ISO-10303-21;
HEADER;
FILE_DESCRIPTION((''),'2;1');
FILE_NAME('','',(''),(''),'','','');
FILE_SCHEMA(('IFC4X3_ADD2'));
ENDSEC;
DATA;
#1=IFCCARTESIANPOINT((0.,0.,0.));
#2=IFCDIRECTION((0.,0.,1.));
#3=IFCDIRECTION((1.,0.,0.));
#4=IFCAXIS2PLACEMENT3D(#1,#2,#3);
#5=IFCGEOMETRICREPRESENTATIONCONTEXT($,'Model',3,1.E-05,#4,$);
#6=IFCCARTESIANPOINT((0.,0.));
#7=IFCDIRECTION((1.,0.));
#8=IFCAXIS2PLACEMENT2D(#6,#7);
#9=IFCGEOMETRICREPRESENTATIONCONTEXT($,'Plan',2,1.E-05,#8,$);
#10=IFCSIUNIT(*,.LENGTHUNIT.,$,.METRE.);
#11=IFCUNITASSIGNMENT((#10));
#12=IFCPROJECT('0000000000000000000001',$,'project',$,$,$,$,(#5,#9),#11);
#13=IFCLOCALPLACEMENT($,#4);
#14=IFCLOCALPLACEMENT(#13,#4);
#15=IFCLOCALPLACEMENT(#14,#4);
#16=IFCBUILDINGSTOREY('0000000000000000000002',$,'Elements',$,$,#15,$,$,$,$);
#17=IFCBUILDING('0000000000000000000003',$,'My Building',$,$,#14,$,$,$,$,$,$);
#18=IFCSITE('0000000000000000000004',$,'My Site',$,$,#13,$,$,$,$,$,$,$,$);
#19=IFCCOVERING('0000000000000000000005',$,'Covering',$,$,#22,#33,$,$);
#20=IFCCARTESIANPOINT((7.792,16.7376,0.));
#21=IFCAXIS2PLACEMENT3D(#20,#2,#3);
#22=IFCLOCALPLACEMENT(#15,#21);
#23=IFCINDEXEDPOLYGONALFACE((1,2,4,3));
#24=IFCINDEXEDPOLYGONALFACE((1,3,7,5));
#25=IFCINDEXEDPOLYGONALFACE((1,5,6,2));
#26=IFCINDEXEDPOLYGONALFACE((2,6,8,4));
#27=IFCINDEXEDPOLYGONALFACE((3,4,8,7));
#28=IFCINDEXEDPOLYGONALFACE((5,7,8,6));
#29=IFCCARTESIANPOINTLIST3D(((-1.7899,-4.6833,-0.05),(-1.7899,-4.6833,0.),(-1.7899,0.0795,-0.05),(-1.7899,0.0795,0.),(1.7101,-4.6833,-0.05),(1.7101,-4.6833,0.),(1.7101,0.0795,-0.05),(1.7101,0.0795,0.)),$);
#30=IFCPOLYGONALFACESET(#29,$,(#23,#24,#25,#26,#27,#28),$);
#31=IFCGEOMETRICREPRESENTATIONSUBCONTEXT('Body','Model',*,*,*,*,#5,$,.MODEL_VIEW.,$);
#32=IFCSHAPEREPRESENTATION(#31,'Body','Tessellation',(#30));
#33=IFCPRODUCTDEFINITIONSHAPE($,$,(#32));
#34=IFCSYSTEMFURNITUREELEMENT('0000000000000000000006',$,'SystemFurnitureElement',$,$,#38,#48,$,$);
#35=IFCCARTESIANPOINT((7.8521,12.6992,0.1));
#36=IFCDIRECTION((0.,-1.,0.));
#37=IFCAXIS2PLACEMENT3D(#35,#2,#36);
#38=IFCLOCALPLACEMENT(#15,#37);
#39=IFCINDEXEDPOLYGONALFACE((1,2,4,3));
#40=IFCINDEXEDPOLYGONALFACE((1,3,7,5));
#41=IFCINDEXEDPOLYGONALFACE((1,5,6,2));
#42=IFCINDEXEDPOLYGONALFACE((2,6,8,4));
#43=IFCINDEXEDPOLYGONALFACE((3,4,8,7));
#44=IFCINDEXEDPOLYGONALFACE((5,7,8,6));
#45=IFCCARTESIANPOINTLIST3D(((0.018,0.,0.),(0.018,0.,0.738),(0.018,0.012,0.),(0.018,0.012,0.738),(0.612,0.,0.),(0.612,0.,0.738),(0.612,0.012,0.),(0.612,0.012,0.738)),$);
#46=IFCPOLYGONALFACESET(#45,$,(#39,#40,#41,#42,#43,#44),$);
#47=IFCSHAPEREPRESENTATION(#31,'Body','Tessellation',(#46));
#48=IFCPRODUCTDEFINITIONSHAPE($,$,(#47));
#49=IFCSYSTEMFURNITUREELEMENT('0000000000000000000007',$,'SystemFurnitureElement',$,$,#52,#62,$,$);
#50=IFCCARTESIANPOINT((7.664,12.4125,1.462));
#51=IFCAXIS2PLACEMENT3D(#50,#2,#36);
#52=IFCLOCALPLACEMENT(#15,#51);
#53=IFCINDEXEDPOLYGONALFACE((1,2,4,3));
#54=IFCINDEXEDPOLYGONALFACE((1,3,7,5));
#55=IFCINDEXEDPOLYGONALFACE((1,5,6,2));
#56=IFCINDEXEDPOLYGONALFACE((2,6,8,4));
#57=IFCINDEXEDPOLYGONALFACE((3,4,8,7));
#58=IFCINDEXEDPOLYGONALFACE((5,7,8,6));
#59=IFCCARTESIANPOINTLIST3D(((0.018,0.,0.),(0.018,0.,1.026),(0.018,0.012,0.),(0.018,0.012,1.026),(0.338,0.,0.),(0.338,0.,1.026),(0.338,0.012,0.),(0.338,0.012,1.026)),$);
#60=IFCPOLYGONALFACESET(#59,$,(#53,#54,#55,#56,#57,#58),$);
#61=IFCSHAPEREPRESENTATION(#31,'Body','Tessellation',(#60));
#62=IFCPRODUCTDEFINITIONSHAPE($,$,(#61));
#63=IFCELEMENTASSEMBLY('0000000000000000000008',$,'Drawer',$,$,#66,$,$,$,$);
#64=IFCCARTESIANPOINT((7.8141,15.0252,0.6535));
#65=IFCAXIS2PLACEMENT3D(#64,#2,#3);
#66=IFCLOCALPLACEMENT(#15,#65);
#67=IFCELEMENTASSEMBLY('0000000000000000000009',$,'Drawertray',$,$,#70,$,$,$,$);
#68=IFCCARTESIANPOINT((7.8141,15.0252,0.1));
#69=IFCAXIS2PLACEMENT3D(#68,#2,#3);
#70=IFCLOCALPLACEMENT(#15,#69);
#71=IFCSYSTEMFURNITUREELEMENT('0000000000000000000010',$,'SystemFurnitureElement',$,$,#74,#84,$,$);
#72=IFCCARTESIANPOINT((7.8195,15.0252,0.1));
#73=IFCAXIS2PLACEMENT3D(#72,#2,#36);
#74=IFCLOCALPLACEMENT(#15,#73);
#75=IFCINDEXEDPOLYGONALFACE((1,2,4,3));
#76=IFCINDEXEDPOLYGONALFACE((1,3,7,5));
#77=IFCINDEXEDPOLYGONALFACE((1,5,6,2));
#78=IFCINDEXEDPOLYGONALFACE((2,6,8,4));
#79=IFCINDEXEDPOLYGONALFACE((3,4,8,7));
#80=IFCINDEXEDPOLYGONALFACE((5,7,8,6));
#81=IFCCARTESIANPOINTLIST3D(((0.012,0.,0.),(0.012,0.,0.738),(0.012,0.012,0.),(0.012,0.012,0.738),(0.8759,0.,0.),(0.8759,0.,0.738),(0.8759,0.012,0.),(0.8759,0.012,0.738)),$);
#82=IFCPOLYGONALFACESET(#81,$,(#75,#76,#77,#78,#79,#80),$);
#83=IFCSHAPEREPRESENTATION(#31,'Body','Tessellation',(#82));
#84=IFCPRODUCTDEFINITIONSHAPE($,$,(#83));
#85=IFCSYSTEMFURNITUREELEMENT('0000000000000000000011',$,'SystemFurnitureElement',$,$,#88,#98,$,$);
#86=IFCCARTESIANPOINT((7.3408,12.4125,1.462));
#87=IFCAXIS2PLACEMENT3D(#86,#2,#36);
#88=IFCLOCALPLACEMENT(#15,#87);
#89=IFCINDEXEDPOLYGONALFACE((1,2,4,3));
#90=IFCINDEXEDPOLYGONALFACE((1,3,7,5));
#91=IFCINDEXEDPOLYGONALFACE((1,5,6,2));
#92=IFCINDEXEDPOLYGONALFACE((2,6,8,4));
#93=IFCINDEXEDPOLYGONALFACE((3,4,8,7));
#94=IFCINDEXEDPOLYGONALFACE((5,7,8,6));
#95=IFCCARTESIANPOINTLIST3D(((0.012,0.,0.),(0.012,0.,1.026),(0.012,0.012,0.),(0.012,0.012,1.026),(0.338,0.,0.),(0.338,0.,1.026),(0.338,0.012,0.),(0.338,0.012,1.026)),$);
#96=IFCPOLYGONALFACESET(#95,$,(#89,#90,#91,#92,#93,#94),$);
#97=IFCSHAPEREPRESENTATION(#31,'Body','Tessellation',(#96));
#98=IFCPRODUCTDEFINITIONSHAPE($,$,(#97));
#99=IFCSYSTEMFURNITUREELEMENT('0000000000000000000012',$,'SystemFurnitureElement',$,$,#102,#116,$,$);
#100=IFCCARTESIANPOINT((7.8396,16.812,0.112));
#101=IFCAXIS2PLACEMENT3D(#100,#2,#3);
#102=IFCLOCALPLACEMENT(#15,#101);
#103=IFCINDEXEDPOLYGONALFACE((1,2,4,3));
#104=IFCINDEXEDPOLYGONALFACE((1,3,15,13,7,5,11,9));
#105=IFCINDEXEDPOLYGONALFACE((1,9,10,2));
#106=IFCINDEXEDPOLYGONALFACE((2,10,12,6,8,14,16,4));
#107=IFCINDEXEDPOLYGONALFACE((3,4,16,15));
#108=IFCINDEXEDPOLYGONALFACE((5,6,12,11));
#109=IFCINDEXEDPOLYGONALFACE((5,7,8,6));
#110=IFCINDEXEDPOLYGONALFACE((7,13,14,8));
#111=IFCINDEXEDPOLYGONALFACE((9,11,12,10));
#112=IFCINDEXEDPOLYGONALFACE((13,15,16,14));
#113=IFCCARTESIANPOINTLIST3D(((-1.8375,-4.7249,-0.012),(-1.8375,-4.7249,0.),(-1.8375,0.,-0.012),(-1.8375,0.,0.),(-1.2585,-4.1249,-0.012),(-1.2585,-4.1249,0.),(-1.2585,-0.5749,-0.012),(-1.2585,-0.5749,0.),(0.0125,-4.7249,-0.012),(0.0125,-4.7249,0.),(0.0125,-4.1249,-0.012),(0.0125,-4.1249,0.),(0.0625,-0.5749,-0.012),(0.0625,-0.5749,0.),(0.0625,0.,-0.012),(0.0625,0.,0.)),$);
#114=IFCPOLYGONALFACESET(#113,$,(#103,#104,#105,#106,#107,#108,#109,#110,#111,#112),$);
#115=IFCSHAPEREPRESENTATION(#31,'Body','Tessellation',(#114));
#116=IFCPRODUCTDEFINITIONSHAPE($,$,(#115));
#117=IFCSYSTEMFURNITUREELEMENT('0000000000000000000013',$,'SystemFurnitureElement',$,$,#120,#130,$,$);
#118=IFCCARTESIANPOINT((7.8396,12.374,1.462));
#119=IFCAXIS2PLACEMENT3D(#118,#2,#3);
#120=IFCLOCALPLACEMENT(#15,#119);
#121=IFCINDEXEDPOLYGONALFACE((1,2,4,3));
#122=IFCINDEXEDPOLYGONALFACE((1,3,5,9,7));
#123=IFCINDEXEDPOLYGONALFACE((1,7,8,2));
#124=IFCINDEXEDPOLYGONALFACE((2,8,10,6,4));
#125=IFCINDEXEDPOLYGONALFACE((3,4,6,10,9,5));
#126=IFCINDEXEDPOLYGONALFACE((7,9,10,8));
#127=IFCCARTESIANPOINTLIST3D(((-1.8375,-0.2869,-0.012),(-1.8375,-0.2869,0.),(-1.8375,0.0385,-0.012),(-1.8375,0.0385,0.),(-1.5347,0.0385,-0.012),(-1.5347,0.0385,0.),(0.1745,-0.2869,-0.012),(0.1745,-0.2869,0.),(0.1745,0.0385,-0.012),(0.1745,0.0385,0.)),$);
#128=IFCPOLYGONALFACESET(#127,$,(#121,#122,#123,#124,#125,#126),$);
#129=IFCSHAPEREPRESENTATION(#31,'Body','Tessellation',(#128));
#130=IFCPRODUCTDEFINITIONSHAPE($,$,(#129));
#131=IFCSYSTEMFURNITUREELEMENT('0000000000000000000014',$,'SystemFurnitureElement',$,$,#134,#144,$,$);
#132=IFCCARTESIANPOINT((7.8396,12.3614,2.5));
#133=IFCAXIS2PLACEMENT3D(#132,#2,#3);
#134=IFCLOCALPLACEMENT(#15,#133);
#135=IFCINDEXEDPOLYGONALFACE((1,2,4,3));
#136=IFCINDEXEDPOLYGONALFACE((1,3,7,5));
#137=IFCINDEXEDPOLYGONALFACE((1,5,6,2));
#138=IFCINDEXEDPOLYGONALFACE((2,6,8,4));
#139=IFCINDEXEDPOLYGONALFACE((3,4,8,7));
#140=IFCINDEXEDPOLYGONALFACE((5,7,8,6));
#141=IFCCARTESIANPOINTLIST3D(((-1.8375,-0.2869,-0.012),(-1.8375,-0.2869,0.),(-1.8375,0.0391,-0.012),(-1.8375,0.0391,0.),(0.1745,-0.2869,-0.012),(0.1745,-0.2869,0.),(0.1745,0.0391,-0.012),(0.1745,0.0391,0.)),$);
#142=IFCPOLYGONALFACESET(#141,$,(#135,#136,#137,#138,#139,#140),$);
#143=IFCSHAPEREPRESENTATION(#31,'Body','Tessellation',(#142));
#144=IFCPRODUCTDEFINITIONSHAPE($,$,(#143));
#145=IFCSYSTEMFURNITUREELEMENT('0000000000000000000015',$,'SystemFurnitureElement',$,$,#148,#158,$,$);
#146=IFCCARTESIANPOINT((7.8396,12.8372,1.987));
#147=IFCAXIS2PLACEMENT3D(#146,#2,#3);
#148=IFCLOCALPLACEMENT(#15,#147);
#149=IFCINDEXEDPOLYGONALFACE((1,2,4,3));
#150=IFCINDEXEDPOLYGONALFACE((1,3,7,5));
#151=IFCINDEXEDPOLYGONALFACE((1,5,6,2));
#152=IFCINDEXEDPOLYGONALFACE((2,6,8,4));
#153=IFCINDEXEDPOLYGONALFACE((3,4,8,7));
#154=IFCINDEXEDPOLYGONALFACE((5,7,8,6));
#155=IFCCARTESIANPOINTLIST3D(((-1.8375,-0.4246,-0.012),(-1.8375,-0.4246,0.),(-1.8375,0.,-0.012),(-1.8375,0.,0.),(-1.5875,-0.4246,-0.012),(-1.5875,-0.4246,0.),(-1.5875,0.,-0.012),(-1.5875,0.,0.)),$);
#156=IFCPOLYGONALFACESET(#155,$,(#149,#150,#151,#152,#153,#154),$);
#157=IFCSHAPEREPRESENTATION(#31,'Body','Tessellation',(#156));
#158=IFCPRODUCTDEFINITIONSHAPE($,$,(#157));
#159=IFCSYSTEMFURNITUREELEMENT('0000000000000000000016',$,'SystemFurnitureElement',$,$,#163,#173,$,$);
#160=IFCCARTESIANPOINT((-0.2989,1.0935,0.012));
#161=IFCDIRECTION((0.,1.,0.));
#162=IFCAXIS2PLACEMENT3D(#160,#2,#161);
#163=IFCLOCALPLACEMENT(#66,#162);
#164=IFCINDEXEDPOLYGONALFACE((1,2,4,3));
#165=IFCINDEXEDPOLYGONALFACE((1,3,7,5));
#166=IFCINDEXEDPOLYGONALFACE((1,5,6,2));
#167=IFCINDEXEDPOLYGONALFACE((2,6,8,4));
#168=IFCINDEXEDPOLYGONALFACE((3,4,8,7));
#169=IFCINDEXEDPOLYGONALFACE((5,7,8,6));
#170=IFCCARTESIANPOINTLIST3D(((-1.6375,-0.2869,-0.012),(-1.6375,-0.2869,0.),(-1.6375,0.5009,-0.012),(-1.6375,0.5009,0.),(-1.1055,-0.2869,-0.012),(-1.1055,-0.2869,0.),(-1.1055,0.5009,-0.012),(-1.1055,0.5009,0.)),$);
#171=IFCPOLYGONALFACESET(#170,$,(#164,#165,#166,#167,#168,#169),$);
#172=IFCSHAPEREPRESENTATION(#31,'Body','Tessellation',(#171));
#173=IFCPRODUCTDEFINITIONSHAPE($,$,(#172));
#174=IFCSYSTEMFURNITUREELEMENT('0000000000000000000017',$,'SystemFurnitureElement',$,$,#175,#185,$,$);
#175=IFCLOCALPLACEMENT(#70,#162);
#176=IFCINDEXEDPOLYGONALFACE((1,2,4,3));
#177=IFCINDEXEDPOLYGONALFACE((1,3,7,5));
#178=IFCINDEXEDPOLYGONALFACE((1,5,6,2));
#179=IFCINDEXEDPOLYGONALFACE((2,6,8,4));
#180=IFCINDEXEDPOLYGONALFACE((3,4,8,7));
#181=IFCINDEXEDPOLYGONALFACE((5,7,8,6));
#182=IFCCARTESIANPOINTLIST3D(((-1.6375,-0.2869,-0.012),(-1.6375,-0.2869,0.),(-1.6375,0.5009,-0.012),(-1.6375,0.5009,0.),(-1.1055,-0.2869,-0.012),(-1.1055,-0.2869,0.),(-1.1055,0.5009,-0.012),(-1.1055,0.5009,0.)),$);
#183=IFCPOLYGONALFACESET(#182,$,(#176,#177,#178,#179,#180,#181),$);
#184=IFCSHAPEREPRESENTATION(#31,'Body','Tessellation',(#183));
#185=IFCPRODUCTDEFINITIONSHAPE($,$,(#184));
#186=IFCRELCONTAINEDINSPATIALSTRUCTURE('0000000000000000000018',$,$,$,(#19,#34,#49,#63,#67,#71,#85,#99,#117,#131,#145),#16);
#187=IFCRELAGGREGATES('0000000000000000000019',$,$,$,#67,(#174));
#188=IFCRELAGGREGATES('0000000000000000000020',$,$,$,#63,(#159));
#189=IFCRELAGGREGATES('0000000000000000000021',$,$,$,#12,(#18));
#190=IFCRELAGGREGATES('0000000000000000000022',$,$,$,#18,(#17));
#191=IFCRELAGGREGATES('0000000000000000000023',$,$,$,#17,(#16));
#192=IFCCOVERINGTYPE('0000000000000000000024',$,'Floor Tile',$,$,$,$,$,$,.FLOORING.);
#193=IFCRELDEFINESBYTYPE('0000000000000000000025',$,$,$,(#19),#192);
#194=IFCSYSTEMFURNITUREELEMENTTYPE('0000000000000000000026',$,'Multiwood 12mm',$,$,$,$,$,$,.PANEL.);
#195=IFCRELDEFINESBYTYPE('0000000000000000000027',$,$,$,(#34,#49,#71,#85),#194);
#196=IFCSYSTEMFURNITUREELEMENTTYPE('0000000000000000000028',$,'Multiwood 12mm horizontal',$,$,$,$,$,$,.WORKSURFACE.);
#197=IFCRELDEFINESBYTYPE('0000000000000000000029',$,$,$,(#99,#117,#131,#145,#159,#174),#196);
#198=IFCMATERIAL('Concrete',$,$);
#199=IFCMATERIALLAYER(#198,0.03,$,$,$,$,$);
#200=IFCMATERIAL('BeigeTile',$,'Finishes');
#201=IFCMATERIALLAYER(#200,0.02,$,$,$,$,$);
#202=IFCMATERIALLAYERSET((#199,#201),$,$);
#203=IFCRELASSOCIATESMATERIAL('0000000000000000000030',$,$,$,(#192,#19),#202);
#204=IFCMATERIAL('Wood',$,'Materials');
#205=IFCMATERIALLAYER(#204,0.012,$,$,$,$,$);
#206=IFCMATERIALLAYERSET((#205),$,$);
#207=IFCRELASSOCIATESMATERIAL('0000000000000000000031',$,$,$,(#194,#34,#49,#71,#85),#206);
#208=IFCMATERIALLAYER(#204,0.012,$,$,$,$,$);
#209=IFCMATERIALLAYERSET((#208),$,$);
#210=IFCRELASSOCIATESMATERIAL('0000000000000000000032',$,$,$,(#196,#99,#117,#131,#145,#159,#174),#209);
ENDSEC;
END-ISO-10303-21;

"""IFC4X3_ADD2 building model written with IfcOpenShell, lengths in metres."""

from ifc_helpers import new_model, si_unit, frame, origin_with_axes, origin_2d_with_axis, place, context, subcontext, project, spatial, line, indexed_curve, outline, extrude, material, layer, layer_set, layer_usage, type_object, element, aggregate, save


model = new_model("IFC4X3_ADD2")

# Units and contexts
model_context = context("Model", 3, precision=1e-05, world=origin_with_axes())
plan_context = context("Plan", 2, precision=1e-05, world=origin_2d_with_axis())
body_context = subcontext(model_context, "Body", "Model", "MODEL_VIEW")
ifc_project = project(units=[si_unit("LENGTHUNIT", "METRE")], contexts=[model_context, plan_context])

# Site, building, storey
site_placement = place(None, origin_with_axes())
site = spatial("IfcSite", under=ifc_project, at=site_placement, Name="My Site")
building_placement = place(site_placement, origin_with_axes())
building = spatial("IfcBuilding", under=site, at=building_placement, Name="My Building")
storey_placement = place(building_placement, origin_with_axes())
storey = spatial("IfcBuildingStorey", under=building, at=storey_placement, Name="Elements")

# Covering
ifc_material_1 = material(Name="Concrete")
ifc_layer_1 = layer(ifc_material_1, 0.03)
ifc_material_2 = material(Name="BeigeTile", Category="Finishes")
ifc_layer_2 = layer(ifc_material_2, 0.02)
ifc_layer_set_1 = layer_set([ifc_layer_1, ifc_layer_2])
ifc_layer_usage_1 = layer_usage(ifc_layer_set_1, "AXIS3", "POSITIVE", -0.05)
covering_type = type_object("IfcCoveringType", Name="Floor Tile", PredefinedType="FLOORING", material=ifc_layer_set_1)
covering_placement = place(storey_placement, frame((7.792, 16.7376, 0.0), z_axis=(0.0, 0.0, 1.0), x_axis=(1.0, 0.0, 0.0)))
element("IfcCovering", 1, at=covering_placement, inside=storey, type_object=covering_type, material=ifc_layer_usage_1, Name="Covering", context=body_context, shape_type="SweptSolid", body=[
    extrude(outline(indexed_curve([(-1.7899, -4.6833), (1.7101, -4.6833), (1.7101, 0.0795), (-1.7899, 0.0795), (-1.7899, -4.6833)])), frame((0.0, 0.0, -0.05), z_axis=(0.0, 0.0, 1.0), x_axis=(1.0, 0.0, 0.0)), (0.0, 0.0, 1.0), 0.05),
])

# System furniture elements
ifc_material_3 = material(Name="Wood", Category="Materials")
ifc_layer_3 = layer(ifc_material_3, 0.012)
ifc_layer_set_2 = layer_set([ifc_layer_3])
ifc_layer_usage_2 = layer_usage(ifc_layer_set_2, "AXIS2", "POSITIVE", 0.0)
system_furniture_element_type_1 = type_object("IfcSystemFurnitureElementType", Name="Multiwood 12mm", PredefinedType="PANEL", material=ifc_layer_set_2)
system_furniture_element_1_placement = place(storey_placement, frame((7.8521, 12.6992, 0.1), z_axis=(0.0, 0.0, 1.0), x_axis=(0.0, -1.0, 0.0)))
element("IfcSystemFurnitureElement", 2, at=system_furniture_element_1_placement, inside=storey, type_object=system_furniture_element_type_1, material=ifc_layer_usage_2, Name="SystemFurnitureElement", context=body_context, shape_type="SweptSolid", body=[
    extrude(outline(indexed_curve([(0.018, 0.0), (0.018, 0.012), (0.612, 0.012), (0.612, 0.0)], segments=[line(1, 2, 3, 4, 1)])), origin_with_axes(), (0.0, 0.0, 1.0), 0.738),
])
ifc_layer_usage_3 = layer_usage(ifc_layer_set_2, "AXIS2", "POSITIVE", 0.0)
system_furniture_element_2_placement = place(storey_placement, frame((7.664, 12.4125, 1.462), z_axis=(0.0, 0.0, 1.0), x_axis=(0.0, -1.0, 0.0)))
element("IfcSystemFurnitureElement", 3, at=system_furniture_element_2_placement, inside=storey, type_object=system_furniture_element_type_1, material=ifc_layer_usage_3, Name="SystemFurnitureElement", context=body_context, shape_type="SweptSolid", body=[
    extrude(outline(indexed_curve([(0.018, 0.0), (0.018, 0.012), (0.338, 0.012), (0.338, 0.0)], segments=[line(1, 2, 3, 4, 1)])), origin_with_axes(), (0.0, 0.0, 1.0), 1.026),
])

# Element assemblies
assembly_1_placement = place(storey_placement, frame((7.8141, 15.0252, 0.6535), z_axis=(0.0, 0.0, 1.0), x_axis=(1.0, 0.0, 0.0)))
assembly_1 = element("IfcElementAssembly", 4, at=assembly_1_placement, inside=storey, Name="Drawer")
assembly_2_placement = place(storey_placement, frame((7.8141, 15.0252, 0.1), z_axis=(0.0, 0.0, 1.0), x_axis=(1.0, 0.0, 0.0)))
assembly_2 = element("IfcElementAssembly", 5, at=assembly_2_placement, inside=storey, Name="Drawertray")

# System furniture elements
ifc_layer_usage_4 = layer_usage(ifc_layer_set_2, "AXIS2", "POSITIVE", 0.0)
system_furniture_element_3_placement = place(storey_placement, frame((7.8195, 15.0252, 0.1), z_axis=(0.0, 0.0, 1.0), x_axis=(0.0, -1.0, 0.0)))
element("IfcSystemFurnitureElement", 6, at=system_furniture_element_3_placement, inside=storey, type_object=system_furniture_element_type_1, material=ifc_layer_usage_4, Name="SystemFurnitureElement", context=body_context, shape_type="SweptSolid", body=[
    extrude(outline(indexed_curve([(0.012, 0.0), (0.012, 0.012), (0.8759, 0.012), (0.8759, 0.0)], segments=[line(1, 2, 3, 4, 1)])), origin_with_axes(), (0.0, 0.0, 1.0), 0.738),
])
ifc_layer_usage_5 = layer_usage(ifc_layer_set_2, "AXIS2", "POSITIVE", 0.0)
system_furniture_element_4_placement = place(storey_placement, frame((7.3408, 12.4125, 1.462), z_axis=(0.0, 0.0, 1.0), x_axis=(0.0, -1.0, 0.0)))
element("IfcSystemFurnitureElement", 7, at=system_furniture_element_4_placement, inside=storey, type_object=system_furniture_element_type_1, material=ifc_layer_usage_5, Name="SystemFurnitureElement", context=body_context, shape_type="SweptSolid", body=[
    extrude(outline(indexed_curve([(0.012, 0.0), (0.012, 0.012), (0.338, 0.012), (0.338, 0.0)], segments=[line(1, 2, 3, 4, 1)])), origin_with_axes(), (0.0, 0.0, 1.0), 1.026),
])
ifc_layer_4 = layer(ifc_material_3, 0.012)
ifc_layer_set_3 = layer_set([ifc_layer_4])
ifc_layer_usage_6 = layer_usage(ifc_layer_set_3, "AXIS3", "POSITIVE", -0.012)
system_furniture_element_type_2 = type_object("IfcSystemFurnitureElementType", Name="Multiwood 12mm horizontal", PredefinedType="WORKSURFACE", material=ifc_layer_set_3)
system_furniture_element_5_placement = place(storey_placement, frame((7.8396, 16.812, 0.112), z_axis=(0.0, 0.0, 1.0), x_axis=(1.0, 0.0, 0.0)))
element("IfcSystemFurnitureElement", 8, at=system_furniture_element_5_placement, inside=storey, type_object=system_furniture_element_type_2, material=ifc_layer_usage_6, Name="SystemFurnitureElement", context=body_context, shape_type="SweptSolid", body=[
    extrude(outline(indexed_curve([(0.0625, -0.5749), (-1.2585, -0.5749), (-1.2585, -4.1249), (0.0125, -4.1249), (0.0125, -4.7249), (-1.8375, -4.7249), (-1.8375, 0.0), (0.0625, 0.0), (0.0625, -0.5749)])), frame((0.0, 0.0, -0.012), z_axis=(0.0, 0.0, 1.0), x_axis=(1.0, 0.0, 0.0)), (0.0, 0.0, 1.0), 0.012),
])
ifc_layer_usage_7 = layer_usage(ifc_layer_set_3, "AXIS3", "POSITIVE", -0.012)
system_furniture_element_6_placement = place(storey_placement, frame((7.8396, 12.374, 1.462), z_axis=(0.0, 0.0, 1.0), x_axis=(1.0, 0.0, 0.0)))
element("IfcSystemFurnitureElement", 9, at=system_furniture_element_6_placement, inside=storey, type_object=system_furniture_element_type_2, material=ifc_layer_usage_7, Name="SystemFurnitureElement", context=body_context, shape_type="SweptSolid", body=[
    extrude(outline(indexed_curve([(0.1745, -0.2869), (-1.8375, -0.2869), (-1.8375, 0.0385), (-1.5347, 0.0385), (0.1745, 0.0385), (0.1745, -0.2869)])), frame((0.0, 0.0, -0.012), z_axis=(0.0, 0.0, 1.0), x_axis=(1.0, 0.0, 0.0)), (0.0, 0.0, 1.0), 0.012),
])
ifc_layer_usage_8 = layer_usage(ifc_layer_set_3, "AXIS3", "POSITIVE", -0.012)
system_furniture_element_7_placement = place(storey_placement, frame((7.8396, 12.3614, 2.5), z_axis=(0.0, 0.0, 1.0), x_axis=(1.0, 0.0, 0.0)))
element("IfcSystemFurnitureElement", 10, at=system_furniture_element_7_placement, inside=storey, type_object=system_furniture_element_type_2, material=ifc_layer_usage_8, Name="SystemFurnitureElement", context=body_context, shape_type="SweptSolid", body=[
    extrude(outline(indexed_curve([(-1.8375, -0.2869), (0.1745, -0.2869), (0.1745, 0.0391), (-1.8375, 0.0391), (-1.8375, -0.2869)])), frame((0.0, 0.0, -0.012), z_axis=(0.0, 0.0, 1.0), x_axis=(1.0, 0.0, 0.0)), (0.0, 0.0, 1.0), 0.012),
])
ifc_layer_usage_9 = layer_usage(ifc_layer_set_3, "AXIS3", "POSITIVE", -0.012)
system_furniture_element_8_placement = place(storey_placement, frame((7.8396, 12.8372, 1.987), z_axis=(0.0, 0.0, 1.0), x_axis=(1.0, 0.0, 0.0)))
element("IfcSystemFurnitureElement", 11, at=system_furniture_element_8_placement, inside=storey, type_object=system_furniture_element_type_2, material=ifc_layer_usage_9, Name="SystemFurnitureElement", context=body_context, shape_type="SweptSolid", body=[
    extrude(outline(indexed_curve([(-1.8375, -0.4246), (-1.5875, -0.4246), (-1.5875, 0.0), (-1.8375, 0.0), (-1.8375, -0.4246)])), frame((0.0, 0.0, -0.012), z_axis=(0.0, 0.0, 1.0), x_axis=(1.0, 0.0, 0.0)), (0.0, 0.0, 1.0), 0.012),
])

# System furniture elements
ifc_layer_usage_10 = layer_usage(ifc_layer_set_3, "AXIS3", "POSITIVE", -0.012)
system_furniture_element_9_placement = place(assembly_1_placement, frame((-0.2989, 1.0935, 0.012), z_axis=(0.0, 0.0, 1.0), x_axis=(0.0, 1.0, 0.0)))
system_furniture_element_9 = element("IfcSystemFurnitureElement", 12, at=system_furniture_element_9_placement, type_object=system_furniture_element_type_2, material=ifc_layer_usage_10, Name="SystemFurnitureElement", context=body_context, shape_type="SweptSolid", body=[
    extrude(outline(indexed_curve([(-1.6375, 0.5009), (-1.1055, 0.5009), (-1.1055, -0.2869), (-1.6375, -0.2869), (-1.6375, 0.5009)])), frame((0.0, 0.0, -0.012), z_axis=(0.0, 0.0, 1.0), x_axis=(1.0, 0.0, 0.0)), (0.0, 0.0, 1.0), 0.012),
])
ifc_layer_usage_11 = layer_usage(ifc_layer_set_3, "AXIS3", "POSITIVE", -0.012)
system_furniture_element_10_placement = place(assembly_2_placement, frame((-0.2989, 1.0935, 0.012), z_axis=(0.0, 0.0, 1.0), x_axis=(0.0, 1.0, 0.0)))
system_furniture_element_10 = element("IfcSystemFurnitureElement", 13, at=system_furniture_element_10_placement, type_object=system_furniture_element_type_2, material=ifc_layer_usage_11, Name="SystemFurnitureElement", context=body_context, shape_type="SweptSolid", body=[
    extrude(outline(indexed_curve([(-1.6375, 0.5009), (-1.1055, 0.5009), (-1.1055, -0.2869), (-1.6375, -0.2869), (-1.6375, 0.5009)])), frame((0.0, 0.0, -0.012), z_axis=(0.0, 0.0, 1.0), x_axis=(1.0, 0.0, 0.0)), (0.0, 0.0, 1.0), 0.012),
])

aggregate(assembly_2, [system_furniture_element_10])
aggregate(assembly_1, [system_furniture_element_9])

save(model, "model.ifc")
